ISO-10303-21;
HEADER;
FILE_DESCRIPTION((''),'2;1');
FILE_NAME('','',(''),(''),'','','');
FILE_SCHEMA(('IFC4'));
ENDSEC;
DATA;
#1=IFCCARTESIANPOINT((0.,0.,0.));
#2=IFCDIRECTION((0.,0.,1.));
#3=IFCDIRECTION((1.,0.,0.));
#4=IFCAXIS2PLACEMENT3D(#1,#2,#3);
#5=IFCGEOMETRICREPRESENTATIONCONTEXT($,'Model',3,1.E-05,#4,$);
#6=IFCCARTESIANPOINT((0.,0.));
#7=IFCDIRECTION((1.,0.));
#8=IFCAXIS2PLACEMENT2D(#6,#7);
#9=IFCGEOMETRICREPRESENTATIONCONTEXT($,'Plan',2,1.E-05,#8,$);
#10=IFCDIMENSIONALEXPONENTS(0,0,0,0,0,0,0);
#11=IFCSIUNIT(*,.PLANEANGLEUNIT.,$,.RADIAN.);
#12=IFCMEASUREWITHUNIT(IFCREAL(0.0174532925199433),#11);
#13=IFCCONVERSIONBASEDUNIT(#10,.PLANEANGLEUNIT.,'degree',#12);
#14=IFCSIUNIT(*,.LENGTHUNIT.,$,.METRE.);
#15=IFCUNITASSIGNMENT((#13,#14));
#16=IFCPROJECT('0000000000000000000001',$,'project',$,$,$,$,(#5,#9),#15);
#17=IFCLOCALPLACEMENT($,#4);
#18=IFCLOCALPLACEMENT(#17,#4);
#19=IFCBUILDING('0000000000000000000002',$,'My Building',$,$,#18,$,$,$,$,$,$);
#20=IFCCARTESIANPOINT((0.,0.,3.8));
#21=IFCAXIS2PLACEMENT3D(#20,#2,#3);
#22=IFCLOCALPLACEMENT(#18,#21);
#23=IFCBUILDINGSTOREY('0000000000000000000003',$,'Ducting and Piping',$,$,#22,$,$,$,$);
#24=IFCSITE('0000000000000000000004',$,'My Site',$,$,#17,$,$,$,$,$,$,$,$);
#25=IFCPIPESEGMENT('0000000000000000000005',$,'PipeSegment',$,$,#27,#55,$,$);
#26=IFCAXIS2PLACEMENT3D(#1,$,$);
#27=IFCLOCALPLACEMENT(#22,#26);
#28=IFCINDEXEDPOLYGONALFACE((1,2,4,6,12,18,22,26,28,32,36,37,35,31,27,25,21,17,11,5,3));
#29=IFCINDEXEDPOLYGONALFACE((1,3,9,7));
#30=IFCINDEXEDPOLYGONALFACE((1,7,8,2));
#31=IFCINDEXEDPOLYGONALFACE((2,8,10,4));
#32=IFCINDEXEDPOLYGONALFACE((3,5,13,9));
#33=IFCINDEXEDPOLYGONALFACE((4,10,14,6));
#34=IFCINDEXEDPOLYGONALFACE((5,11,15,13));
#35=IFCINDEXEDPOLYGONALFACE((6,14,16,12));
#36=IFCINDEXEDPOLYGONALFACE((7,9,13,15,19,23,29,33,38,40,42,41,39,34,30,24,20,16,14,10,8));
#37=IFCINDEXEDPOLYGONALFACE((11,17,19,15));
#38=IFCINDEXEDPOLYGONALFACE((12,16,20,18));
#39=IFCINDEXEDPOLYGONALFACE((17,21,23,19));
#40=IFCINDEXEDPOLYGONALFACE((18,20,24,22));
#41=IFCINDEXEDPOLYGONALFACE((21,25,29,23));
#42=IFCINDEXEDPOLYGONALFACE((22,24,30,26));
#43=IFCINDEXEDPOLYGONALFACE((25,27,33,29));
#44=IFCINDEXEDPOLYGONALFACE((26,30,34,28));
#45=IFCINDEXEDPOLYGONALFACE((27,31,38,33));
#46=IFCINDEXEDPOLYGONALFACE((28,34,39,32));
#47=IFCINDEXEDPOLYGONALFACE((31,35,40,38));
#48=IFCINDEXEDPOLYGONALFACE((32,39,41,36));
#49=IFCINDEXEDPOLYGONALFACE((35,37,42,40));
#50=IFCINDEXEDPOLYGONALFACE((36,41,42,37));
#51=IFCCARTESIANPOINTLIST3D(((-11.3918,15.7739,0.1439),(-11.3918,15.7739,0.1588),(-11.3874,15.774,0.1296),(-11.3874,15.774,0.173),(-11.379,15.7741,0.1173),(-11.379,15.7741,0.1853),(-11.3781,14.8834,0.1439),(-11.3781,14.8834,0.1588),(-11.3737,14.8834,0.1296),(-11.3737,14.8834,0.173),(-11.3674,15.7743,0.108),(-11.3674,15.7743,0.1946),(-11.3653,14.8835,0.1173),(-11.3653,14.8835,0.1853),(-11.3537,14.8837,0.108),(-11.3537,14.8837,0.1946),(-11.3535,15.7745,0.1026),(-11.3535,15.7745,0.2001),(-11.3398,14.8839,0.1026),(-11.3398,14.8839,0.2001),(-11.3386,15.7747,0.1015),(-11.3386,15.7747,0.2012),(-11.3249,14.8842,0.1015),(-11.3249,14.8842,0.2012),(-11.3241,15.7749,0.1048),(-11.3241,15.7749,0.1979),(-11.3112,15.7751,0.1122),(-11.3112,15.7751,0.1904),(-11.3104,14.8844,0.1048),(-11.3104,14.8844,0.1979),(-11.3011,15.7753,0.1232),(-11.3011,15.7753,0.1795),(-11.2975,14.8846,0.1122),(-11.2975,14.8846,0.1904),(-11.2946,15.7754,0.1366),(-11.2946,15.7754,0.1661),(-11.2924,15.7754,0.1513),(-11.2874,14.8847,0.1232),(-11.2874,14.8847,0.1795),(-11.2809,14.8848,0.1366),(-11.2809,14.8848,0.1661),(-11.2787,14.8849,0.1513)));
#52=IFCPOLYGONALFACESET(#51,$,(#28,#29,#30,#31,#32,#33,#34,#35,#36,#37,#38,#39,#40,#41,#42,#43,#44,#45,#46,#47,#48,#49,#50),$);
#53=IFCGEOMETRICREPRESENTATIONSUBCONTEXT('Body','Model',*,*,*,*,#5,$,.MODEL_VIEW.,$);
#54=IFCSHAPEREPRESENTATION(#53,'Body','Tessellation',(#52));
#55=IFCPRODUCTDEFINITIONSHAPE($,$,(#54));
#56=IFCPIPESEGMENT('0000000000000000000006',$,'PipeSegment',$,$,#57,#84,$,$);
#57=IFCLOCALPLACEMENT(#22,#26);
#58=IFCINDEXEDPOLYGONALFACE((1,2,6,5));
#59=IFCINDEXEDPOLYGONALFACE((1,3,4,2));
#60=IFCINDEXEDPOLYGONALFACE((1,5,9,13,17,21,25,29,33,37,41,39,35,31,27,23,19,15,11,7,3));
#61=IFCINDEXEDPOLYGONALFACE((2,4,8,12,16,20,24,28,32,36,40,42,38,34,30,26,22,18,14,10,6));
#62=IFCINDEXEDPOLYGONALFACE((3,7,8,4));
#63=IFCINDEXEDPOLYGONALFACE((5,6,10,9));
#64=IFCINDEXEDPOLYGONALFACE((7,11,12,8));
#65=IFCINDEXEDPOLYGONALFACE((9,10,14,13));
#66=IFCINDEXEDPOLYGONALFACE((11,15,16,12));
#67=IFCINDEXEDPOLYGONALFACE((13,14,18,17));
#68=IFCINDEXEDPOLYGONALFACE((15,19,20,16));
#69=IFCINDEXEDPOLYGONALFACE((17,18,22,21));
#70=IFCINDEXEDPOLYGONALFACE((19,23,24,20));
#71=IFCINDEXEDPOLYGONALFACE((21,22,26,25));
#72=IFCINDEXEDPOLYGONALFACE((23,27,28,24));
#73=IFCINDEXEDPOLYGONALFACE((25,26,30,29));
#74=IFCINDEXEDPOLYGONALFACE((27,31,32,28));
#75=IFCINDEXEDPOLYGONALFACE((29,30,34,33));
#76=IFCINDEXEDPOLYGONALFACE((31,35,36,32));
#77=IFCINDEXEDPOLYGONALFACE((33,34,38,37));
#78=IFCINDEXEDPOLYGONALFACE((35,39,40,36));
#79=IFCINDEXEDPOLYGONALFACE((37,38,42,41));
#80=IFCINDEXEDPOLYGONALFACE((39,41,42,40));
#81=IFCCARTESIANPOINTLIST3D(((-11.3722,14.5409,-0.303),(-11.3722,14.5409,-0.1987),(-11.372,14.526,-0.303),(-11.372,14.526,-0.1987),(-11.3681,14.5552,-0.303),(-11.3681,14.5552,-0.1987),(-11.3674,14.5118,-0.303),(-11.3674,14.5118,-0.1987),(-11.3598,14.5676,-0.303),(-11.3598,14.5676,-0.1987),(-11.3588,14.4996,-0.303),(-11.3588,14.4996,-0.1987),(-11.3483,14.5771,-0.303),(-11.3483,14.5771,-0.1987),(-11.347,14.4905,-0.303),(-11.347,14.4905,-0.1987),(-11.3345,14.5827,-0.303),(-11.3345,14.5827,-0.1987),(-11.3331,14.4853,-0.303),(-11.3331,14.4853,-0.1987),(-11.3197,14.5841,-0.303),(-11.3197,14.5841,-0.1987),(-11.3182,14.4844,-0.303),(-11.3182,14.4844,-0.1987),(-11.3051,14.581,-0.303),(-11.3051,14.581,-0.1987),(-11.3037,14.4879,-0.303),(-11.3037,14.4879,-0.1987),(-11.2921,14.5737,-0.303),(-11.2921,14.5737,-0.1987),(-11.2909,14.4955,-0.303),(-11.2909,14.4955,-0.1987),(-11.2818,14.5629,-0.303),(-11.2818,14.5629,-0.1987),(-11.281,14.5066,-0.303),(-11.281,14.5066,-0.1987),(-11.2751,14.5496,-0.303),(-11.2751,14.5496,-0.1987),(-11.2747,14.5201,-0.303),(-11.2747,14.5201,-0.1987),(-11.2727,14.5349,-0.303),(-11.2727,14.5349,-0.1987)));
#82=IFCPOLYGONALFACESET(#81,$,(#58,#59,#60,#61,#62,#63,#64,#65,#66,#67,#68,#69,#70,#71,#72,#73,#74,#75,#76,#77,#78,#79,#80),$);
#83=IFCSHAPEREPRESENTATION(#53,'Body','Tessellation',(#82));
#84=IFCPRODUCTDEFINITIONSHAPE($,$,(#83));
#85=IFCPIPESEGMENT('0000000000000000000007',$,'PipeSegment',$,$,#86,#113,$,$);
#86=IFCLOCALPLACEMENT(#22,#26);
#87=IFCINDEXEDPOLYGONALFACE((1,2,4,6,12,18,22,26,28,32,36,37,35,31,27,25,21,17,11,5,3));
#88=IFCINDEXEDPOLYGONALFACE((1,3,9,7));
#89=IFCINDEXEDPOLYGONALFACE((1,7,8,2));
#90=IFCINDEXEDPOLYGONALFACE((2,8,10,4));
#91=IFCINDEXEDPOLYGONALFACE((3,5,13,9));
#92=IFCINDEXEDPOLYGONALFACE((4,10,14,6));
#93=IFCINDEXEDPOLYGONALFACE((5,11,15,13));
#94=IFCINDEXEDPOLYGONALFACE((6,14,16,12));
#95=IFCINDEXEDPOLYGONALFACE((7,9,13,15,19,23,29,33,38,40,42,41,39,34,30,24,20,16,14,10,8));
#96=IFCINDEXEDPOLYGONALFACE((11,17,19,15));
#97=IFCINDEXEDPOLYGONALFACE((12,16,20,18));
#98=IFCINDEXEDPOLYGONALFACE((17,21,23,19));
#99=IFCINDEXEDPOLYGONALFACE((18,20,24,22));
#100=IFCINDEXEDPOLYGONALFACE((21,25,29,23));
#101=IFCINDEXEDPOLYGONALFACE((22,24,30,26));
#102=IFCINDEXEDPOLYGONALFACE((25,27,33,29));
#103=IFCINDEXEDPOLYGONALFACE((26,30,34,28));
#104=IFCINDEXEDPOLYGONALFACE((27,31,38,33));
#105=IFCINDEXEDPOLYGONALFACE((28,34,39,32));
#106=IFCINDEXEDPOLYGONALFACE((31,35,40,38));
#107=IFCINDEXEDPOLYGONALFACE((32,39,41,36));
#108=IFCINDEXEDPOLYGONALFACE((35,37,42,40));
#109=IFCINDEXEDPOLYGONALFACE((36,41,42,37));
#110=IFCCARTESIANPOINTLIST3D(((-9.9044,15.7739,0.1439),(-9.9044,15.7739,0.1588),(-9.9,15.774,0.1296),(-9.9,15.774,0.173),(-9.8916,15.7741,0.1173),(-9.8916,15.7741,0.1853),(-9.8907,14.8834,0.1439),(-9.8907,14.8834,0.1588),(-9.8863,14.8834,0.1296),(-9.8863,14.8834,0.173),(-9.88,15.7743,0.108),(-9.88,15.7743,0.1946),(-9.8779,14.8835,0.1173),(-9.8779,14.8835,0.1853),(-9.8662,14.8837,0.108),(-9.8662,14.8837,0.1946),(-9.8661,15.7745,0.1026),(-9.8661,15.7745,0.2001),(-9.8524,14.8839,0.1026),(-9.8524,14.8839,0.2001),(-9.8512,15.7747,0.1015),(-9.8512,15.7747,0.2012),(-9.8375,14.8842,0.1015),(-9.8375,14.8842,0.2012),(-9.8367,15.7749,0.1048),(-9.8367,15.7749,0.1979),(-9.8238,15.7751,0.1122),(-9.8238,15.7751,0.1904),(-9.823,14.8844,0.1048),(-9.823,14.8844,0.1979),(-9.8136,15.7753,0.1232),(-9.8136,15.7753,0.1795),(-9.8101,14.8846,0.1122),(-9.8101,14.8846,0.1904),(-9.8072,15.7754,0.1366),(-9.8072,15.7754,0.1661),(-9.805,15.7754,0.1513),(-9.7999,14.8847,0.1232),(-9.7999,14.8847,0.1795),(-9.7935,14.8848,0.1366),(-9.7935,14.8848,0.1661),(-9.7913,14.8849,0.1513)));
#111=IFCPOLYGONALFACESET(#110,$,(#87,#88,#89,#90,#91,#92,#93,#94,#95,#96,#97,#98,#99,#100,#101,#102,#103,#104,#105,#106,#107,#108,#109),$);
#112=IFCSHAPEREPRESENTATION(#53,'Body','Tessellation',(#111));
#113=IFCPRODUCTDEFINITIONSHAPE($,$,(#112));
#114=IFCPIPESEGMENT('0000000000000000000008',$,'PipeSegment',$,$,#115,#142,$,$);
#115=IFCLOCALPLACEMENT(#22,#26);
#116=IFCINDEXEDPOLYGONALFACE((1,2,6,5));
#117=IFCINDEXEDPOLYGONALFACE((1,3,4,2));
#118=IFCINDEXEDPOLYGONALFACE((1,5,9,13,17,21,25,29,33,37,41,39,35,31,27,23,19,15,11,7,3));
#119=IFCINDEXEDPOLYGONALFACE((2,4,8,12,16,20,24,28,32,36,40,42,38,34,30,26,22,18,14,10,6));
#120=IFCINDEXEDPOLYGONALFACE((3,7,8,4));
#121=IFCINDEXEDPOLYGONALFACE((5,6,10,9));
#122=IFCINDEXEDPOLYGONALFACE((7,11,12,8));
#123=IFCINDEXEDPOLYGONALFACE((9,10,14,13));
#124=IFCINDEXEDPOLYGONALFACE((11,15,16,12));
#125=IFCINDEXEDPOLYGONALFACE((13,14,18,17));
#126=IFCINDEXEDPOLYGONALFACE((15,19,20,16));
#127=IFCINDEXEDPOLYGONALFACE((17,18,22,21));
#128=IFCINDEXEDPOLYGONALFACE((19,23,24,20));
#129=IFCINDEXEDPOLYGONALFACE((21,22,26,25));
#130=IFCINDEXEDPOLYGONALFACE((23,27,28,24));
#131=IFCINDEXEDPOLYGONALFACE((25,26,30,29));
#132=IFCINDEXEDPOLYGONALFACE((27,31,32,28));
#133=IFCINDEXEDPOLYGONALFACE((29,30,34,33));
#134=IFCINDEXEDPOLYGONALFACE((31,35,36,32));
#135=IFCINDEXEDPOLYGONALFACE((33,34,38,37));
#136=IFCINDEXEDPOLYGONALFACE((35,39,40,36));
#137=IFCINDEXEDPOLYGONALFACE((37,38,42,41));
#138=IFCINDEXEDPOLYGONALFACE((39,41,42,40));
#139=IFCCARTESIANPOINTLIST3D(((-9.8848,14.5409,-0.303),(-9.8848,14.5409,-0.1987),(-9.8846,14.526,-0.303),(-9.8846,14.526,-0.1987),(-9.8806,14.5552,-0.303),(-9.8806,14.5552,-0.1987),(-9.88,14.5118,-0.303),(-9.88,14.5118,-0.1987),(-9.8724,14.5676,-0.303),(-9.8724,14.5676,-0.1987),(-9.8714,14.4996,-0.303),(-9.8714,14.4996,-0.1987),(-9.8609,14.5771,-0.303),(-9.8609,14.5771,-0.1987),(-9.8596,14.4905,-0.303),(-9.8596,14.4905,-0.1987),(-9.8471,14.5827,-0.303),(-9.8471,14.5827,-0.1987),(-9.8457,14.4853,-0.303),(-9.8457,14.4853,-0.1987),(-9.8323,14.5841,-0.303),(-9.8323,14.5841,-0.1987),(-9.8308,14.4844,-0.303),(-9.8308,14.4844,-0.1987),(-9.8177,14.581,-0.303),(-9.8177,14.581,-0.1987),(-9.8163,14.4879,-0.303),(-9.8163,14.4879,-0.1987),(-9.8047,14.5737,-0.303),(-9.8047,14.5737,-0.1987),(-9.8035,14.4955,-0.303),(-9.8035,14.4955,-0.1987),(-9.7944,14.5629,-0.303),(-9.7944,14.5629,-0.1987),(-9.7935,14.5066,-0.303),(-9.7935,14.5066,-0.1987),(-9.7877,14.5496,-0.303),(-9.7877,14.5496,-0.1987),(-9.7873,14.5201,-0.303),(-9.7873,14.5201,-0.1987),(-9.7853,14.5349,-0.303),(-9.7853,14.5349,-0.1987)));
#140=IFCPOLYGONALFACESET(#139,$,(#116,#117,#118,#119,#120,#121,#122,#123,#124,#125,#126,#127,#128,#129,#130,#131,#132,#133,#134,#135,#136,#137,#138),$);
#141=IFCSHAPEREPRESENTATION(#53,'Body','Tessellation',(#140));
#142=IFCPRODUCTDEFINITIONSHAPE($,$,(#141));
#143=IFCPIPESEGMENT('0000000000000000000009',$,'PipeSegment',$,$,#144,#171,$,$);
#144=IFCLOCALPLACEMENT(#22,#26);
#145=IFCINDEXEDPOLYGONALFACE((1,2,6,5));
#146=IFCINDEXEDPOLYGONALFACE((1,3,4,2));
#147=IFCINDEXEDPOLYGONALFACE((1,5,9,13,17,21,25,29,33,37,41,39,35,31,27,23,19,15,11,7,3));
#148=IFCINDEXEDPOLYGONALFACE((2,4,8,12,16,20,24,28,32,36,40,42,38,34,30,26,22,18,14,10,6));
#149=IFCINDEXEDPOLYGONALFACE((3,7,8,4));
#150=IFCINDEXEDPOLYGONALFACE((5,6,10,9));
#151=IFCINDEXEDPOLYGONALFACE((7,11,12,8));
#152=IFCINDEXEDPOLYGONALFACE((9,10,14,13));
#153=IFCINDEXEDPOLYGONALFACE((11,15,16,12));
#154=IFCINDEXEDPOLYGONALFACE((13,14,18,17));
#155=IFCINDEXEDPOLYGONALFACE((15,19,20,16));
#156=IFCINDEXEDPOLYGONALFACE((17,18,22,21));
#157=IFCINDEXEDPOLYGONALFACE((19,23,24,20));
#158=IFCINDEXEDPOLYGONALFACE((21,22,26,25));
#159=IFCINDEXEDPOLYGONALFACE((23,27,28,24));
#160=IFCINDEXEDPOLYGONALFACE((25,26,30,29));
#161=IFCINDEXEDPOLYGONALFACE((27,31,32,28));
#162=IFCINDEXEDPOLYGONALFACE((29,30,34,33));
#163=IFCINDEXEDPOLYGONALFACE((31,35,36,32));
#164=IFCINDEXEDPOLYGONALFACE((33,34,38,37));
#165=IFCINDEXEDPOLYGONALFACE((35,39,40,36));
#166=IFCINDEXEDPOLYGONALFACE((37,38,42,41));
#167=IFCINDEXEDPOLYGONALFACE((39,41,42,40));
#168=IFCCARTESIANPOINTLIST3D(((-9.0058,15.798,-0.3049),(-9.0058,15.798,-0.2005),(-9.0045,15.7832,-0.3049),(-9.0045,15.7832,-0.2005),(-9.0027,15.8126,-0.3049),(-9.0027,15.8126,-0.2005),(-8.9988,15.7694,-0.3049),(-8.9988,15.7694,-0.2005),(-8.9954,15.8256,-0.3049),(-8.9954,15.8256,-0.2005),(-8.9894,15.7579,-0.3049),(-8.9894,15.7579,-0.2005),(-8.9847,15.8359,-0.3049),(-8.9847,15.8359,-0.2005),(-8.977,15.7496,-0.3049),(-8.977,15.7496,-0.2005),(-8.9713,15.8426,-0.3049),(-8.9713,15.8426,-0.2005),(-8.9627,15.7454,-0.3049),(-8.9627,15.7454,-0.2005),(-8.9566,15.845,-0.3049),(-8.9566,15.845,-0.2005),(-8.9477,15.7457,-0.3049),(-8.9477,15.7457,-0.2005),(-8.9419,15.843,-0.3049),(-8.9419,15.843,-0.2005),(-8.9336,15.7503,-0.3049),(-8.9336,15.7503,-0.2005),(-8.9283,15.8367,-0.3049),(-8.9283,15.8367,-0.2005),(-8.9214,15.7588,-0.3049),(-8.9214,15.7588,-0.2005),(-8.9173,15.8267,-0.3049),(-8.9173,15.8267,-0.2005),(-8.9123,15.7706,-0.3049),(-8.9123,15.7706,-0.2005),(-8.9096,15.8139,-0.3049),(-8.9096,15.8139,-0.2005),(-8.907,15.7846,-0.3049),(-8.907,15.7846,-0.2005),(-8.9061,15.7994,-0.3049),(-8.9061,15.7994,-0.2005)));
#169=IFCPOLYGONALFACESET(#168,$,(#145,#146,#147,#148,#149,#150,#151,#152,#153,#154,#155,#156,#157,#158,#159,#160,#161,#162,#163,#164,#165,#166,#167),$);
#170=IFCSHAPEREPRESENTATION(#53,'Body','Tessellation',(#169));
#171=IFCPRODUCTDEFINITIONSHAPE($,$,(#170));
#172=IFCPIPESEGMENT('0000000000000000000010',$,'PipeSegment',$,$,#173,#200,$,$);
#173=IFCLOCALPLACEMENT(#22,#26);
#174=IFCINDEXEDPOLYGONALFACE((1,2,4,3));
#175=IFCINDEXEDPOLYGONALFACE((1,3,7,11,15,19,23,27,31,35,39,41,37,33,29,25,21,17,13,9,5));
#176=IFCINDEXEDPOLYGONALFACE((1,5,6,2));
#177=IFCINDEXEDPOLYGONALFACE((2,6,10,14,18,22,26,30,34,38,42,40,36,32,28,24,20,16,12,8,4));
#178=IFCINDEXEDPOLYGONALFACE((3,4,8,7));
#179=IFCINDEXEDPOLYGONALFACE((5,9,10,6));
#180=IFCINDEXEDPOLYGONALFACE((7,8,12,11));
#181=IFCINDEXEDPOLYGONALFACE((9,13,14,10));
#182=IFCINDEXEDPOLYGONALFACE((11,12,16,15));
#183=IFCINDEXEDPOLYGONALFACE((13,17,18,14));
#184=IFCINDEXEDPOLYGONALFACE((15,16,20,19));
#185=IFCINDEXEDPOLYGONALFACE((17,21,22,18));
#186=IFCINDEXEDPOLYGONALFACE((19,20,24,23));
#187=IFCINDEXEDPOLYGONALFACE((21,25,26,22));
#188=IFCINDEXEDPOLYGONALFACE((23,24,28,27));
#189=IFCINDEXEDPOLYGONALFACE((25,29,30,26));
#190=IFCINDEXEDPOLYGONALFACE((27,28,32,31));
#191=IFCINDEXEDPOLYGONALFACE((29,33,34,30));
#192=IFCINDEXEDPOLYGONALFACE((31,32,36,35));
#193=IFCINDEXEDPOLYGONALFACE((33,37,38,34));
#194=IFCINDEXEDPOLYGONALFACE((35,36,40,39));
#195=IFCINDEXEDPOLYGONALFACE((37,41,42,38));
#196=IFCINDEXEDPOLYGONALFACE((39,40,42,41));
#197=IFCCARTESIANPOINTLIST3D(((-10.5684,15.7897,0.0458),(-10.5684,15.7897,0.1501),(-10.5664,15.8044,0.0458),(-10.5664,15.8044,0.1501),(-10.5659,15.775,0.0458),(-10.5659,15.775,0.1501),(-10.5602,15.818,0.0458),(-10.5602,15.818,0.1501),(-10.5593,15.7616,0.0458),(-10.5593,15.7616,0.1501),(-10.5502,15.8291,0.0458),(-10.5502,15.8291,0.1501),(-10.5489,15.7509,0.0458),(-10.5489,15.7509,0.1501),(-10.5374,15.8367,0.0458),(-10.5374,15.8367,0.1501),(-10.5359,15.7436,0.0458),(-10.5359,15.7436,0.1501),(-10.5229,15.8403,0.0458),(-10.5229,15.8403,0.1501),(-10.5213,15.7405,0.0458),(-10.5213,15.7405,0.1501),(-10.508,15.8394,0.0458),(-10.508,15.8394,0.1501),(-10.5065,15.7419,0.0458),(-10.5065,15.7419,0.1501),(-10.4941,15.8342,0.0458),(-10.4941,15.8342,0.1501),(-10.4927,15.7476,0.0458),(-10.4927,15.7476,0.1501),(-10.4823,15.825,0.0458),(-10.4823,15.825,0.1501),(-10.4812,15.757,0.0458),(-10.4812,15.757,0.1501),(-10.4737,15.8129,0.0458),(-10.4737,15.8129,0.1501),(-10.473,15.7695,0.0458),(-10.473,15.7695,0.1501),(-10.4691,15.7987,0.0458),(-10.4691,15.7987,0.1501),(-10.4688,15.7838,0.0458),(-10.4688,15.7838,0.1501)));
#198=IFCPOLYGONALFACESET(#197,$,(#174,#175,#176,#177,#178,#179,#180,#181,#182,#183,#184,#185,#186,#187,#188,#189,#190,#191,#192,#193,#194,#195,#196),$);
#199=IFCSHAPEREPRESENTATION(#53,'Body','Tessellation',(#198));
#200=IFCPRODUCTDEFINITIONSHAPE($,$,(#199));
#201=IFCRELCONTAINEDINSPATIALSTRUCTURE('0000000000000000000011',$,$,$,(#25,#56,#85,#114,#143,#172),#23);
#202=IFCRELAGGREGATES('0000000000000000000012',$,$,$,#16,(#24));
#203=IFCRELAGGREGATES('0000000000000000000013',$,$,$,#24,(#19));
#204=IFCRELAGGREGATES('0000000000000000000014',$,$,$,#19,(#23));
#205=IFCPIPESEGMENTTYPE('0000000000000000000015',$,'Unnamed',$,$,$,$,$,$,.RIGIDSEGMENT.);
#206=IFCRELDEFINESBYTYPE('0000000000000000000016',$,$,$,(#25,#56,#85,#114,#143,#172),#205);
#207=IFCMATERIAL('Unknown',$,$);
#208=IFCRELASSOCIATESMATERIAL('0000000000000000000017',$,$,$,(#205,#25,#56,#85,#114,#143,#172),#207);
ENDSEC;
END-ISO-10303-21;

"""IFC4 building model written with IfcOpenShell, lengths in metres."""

from ifc_helpers import new_model, entity, si_unit, converted_unit, frame, origin_with_axes, origin_2d_with_axis, place, context, subcontext, project, spatial, circle, extrude, material, material_profile, profile_set, profile_usage, type_object, element, save


model = new_model("IFC4")

# Units and contexts
model_context = context("Model", 3, precision=1e-05, world=origin_with_axes())
plan_context = context("Plan", 2, precision=1e-05, world=origin_2d_with_axis())
body_context = subcontext(model_context, "Body", "Model", "MODEL_VIEW")
ifc_project = project(units=[converted_unit("PLANEANGLEUNIT", "degree", entity("IfcReal", 0.0174532925199433), si_unit("PLANEANGLEUNIT", "RADIAN"), dimensions=[0, 0, 0, 0, 0, 0, 0]), si_unit("LENGTHUNIT", "METRE")], contexts=[model_context, plan_context])

# Site, building, storey
site_placement = place(None, origin_with_axes())
site = spatial("IfcSite", under=ifc_project, at=site_placement, Name="My Site")
building_placement = place(site_placement, origin_with_axes())
building = spatial("IfcBuilding", under=site, at=building_placement, Name="My Building")
storey_placement = place(building_placement, frame((0.0, 0.0, 3.8), z_axis=(0.0, 0.0, 1.0), x_axis=(1.0, 0.0, 0.0)))
storey = spatial("IfcBuildingStorey", under=building, at=storey_placement, Name="Ducting and Piping")

# Pipe segments
ifc_material = material(Name="Unknown")
ifc_material_profile_1 = material_profile(ifc_material, circle(Radius=0.05))
ifc_profile_set_1 = profile_set([ifc_material_profile_1])
pipe_segment_type = type_object("IfcPipeSegmentType", Name="Unnamed", PredefinedType="RIGIDSEGMENT", material=ifc_profile_set_1)
ifc_profile_usage_1 = profile_usage(ifc_profile_set_1, cardinal=5)
pipe_segment_1_placement = place(storey_placement, frame((-11.3424, 15.7747, 0.1513), z_axis=(0.015385, -0.999882, 0.0), x_axis=(0.999882, 0.015385, 0.0)))
element("IfcPipeSegment", 1, at=pipe_segment_1_placement, inside=storey, type_object=pipe_segment_type, material=ifc_profile_usage_1, Name="PipeSegment", context=body_context, shape_type="SweptSolid", body=[
    extrude(circle(Radius=0.05), origin_with_axes(), (0.0, 0.0, 1.0), 0.8907),
])
ifc_profile_usage_2 = profile_usage(ifc_profile_set_1, cardinal=5)
pipe_segment_2_placement = place(storey_placement, frame((-11.3227, 14.5342, -0.303), z_axis=(0.0, 0.0, 1.0), x_axis=(0.999889, 0.014879, 0.0)))
element("IfcPipeSegment", 2, at=pipe_segment_2_placement, inside=storey, type_object=pipe_segment_type, material=ifc_profile_usage_2, Name="PipeSegment", context=body_context, shape_type="SweptSolid", body=[
    extrude(circle(Radius=0.05), origin_with_axes(), (0.0, 0.0, 1.0), 0.1043),
])
ifc_profile_usage_3 = profile_usage(ifc_profile_set_1, cardinal=5)
pipe_segment_3_placement = place(storey_placement, frame((-9.855, 15.7747, 0.1513), z_axis=(0.015385, -0.999882, 0.0), x_axis=(0.999882, 0.015385, 0.0)))
element("IfcPipeSegment", 3, at=pipe_segment_3_placement, inside=storey, type_object=pipe_segment_type, material=ifc_profile_usage_3, Name="PipeSegment", context=body_context, shape_type="SweptSolid", body=[
    extrude(circle(Radius=0.05), origin_with_axes(), (0.0, 0.0, 1.0), 0.8907),
])
ifc_profile_usage_4 = profile_usage(ifc_profile_set_1, cardinal=5)
pipe_segment_4_placement = place(storey_placement, frame((-9.8353, 14.5342, -0.303), z_axis=(0.0, 0.0, 1.0), x_axis=(0.999889, 0.014879, 0.0)))
element("IfcPipeSegment", 4, at=pipe_segment_4_placement, inside=storey, type_object=pipe_segment_type, material=ifc_profile_usage_4, Name="PipeSegment", context=body_context, shape_type="SweptSolid", body=[
    extrude(circle(Radius=0.05), origin_with_axes(), (0.0, 0.0, 1.0), 0.1043),
])
ifc_profile_usage_5 = profile_usage(ifc_profile_set_1, cardinal=5)
pipe_segment_5_placement = place(storey_placement, frame((-8.9559, 15.795, -0.3049), z_axis=(0.0, 0.0, 1.0), x_axis=(-0.014266, 0.999898, 0.0)))
element("IfcPipeSegment", 5, at=pipe_segment_5_placement, inside=storey, type_object=pipe_segment_type, material=ifc_profile_usage_5, Name="PipeSegment", context=body_context, shape_type="SweptSolid", body=[
    extrude(circle(Radius=0.05), origin_with_axes(), (0.0, 0.0, 1.0), 0.1043),
])
ifc_profile_usage_6 = profile_usage(ifc_profile_set_1, cardinal=5)
pipe_segment_6_placement = place(storey_placement, frame((-10.5184, 15.7905, 0.0458), z_axis=(0.0, 0.0, 1.0), x_axis=(-0.999873, -0.015924, 0.0)))
element("IfcPipeSegment", 6, at=pipe_segment_6_placement, inside=storey, type_object=pipe_segment_type, material=ifc_profile_usage_6, Name="PipeSegment", context=body_context, shape_type="SweptSolid", body=[
    extrude(circle(Radius=0.05), origin_with_axes(), (0.0, 0.0, 1.0), 0.1043),
])

save(model, "model.ifc")
